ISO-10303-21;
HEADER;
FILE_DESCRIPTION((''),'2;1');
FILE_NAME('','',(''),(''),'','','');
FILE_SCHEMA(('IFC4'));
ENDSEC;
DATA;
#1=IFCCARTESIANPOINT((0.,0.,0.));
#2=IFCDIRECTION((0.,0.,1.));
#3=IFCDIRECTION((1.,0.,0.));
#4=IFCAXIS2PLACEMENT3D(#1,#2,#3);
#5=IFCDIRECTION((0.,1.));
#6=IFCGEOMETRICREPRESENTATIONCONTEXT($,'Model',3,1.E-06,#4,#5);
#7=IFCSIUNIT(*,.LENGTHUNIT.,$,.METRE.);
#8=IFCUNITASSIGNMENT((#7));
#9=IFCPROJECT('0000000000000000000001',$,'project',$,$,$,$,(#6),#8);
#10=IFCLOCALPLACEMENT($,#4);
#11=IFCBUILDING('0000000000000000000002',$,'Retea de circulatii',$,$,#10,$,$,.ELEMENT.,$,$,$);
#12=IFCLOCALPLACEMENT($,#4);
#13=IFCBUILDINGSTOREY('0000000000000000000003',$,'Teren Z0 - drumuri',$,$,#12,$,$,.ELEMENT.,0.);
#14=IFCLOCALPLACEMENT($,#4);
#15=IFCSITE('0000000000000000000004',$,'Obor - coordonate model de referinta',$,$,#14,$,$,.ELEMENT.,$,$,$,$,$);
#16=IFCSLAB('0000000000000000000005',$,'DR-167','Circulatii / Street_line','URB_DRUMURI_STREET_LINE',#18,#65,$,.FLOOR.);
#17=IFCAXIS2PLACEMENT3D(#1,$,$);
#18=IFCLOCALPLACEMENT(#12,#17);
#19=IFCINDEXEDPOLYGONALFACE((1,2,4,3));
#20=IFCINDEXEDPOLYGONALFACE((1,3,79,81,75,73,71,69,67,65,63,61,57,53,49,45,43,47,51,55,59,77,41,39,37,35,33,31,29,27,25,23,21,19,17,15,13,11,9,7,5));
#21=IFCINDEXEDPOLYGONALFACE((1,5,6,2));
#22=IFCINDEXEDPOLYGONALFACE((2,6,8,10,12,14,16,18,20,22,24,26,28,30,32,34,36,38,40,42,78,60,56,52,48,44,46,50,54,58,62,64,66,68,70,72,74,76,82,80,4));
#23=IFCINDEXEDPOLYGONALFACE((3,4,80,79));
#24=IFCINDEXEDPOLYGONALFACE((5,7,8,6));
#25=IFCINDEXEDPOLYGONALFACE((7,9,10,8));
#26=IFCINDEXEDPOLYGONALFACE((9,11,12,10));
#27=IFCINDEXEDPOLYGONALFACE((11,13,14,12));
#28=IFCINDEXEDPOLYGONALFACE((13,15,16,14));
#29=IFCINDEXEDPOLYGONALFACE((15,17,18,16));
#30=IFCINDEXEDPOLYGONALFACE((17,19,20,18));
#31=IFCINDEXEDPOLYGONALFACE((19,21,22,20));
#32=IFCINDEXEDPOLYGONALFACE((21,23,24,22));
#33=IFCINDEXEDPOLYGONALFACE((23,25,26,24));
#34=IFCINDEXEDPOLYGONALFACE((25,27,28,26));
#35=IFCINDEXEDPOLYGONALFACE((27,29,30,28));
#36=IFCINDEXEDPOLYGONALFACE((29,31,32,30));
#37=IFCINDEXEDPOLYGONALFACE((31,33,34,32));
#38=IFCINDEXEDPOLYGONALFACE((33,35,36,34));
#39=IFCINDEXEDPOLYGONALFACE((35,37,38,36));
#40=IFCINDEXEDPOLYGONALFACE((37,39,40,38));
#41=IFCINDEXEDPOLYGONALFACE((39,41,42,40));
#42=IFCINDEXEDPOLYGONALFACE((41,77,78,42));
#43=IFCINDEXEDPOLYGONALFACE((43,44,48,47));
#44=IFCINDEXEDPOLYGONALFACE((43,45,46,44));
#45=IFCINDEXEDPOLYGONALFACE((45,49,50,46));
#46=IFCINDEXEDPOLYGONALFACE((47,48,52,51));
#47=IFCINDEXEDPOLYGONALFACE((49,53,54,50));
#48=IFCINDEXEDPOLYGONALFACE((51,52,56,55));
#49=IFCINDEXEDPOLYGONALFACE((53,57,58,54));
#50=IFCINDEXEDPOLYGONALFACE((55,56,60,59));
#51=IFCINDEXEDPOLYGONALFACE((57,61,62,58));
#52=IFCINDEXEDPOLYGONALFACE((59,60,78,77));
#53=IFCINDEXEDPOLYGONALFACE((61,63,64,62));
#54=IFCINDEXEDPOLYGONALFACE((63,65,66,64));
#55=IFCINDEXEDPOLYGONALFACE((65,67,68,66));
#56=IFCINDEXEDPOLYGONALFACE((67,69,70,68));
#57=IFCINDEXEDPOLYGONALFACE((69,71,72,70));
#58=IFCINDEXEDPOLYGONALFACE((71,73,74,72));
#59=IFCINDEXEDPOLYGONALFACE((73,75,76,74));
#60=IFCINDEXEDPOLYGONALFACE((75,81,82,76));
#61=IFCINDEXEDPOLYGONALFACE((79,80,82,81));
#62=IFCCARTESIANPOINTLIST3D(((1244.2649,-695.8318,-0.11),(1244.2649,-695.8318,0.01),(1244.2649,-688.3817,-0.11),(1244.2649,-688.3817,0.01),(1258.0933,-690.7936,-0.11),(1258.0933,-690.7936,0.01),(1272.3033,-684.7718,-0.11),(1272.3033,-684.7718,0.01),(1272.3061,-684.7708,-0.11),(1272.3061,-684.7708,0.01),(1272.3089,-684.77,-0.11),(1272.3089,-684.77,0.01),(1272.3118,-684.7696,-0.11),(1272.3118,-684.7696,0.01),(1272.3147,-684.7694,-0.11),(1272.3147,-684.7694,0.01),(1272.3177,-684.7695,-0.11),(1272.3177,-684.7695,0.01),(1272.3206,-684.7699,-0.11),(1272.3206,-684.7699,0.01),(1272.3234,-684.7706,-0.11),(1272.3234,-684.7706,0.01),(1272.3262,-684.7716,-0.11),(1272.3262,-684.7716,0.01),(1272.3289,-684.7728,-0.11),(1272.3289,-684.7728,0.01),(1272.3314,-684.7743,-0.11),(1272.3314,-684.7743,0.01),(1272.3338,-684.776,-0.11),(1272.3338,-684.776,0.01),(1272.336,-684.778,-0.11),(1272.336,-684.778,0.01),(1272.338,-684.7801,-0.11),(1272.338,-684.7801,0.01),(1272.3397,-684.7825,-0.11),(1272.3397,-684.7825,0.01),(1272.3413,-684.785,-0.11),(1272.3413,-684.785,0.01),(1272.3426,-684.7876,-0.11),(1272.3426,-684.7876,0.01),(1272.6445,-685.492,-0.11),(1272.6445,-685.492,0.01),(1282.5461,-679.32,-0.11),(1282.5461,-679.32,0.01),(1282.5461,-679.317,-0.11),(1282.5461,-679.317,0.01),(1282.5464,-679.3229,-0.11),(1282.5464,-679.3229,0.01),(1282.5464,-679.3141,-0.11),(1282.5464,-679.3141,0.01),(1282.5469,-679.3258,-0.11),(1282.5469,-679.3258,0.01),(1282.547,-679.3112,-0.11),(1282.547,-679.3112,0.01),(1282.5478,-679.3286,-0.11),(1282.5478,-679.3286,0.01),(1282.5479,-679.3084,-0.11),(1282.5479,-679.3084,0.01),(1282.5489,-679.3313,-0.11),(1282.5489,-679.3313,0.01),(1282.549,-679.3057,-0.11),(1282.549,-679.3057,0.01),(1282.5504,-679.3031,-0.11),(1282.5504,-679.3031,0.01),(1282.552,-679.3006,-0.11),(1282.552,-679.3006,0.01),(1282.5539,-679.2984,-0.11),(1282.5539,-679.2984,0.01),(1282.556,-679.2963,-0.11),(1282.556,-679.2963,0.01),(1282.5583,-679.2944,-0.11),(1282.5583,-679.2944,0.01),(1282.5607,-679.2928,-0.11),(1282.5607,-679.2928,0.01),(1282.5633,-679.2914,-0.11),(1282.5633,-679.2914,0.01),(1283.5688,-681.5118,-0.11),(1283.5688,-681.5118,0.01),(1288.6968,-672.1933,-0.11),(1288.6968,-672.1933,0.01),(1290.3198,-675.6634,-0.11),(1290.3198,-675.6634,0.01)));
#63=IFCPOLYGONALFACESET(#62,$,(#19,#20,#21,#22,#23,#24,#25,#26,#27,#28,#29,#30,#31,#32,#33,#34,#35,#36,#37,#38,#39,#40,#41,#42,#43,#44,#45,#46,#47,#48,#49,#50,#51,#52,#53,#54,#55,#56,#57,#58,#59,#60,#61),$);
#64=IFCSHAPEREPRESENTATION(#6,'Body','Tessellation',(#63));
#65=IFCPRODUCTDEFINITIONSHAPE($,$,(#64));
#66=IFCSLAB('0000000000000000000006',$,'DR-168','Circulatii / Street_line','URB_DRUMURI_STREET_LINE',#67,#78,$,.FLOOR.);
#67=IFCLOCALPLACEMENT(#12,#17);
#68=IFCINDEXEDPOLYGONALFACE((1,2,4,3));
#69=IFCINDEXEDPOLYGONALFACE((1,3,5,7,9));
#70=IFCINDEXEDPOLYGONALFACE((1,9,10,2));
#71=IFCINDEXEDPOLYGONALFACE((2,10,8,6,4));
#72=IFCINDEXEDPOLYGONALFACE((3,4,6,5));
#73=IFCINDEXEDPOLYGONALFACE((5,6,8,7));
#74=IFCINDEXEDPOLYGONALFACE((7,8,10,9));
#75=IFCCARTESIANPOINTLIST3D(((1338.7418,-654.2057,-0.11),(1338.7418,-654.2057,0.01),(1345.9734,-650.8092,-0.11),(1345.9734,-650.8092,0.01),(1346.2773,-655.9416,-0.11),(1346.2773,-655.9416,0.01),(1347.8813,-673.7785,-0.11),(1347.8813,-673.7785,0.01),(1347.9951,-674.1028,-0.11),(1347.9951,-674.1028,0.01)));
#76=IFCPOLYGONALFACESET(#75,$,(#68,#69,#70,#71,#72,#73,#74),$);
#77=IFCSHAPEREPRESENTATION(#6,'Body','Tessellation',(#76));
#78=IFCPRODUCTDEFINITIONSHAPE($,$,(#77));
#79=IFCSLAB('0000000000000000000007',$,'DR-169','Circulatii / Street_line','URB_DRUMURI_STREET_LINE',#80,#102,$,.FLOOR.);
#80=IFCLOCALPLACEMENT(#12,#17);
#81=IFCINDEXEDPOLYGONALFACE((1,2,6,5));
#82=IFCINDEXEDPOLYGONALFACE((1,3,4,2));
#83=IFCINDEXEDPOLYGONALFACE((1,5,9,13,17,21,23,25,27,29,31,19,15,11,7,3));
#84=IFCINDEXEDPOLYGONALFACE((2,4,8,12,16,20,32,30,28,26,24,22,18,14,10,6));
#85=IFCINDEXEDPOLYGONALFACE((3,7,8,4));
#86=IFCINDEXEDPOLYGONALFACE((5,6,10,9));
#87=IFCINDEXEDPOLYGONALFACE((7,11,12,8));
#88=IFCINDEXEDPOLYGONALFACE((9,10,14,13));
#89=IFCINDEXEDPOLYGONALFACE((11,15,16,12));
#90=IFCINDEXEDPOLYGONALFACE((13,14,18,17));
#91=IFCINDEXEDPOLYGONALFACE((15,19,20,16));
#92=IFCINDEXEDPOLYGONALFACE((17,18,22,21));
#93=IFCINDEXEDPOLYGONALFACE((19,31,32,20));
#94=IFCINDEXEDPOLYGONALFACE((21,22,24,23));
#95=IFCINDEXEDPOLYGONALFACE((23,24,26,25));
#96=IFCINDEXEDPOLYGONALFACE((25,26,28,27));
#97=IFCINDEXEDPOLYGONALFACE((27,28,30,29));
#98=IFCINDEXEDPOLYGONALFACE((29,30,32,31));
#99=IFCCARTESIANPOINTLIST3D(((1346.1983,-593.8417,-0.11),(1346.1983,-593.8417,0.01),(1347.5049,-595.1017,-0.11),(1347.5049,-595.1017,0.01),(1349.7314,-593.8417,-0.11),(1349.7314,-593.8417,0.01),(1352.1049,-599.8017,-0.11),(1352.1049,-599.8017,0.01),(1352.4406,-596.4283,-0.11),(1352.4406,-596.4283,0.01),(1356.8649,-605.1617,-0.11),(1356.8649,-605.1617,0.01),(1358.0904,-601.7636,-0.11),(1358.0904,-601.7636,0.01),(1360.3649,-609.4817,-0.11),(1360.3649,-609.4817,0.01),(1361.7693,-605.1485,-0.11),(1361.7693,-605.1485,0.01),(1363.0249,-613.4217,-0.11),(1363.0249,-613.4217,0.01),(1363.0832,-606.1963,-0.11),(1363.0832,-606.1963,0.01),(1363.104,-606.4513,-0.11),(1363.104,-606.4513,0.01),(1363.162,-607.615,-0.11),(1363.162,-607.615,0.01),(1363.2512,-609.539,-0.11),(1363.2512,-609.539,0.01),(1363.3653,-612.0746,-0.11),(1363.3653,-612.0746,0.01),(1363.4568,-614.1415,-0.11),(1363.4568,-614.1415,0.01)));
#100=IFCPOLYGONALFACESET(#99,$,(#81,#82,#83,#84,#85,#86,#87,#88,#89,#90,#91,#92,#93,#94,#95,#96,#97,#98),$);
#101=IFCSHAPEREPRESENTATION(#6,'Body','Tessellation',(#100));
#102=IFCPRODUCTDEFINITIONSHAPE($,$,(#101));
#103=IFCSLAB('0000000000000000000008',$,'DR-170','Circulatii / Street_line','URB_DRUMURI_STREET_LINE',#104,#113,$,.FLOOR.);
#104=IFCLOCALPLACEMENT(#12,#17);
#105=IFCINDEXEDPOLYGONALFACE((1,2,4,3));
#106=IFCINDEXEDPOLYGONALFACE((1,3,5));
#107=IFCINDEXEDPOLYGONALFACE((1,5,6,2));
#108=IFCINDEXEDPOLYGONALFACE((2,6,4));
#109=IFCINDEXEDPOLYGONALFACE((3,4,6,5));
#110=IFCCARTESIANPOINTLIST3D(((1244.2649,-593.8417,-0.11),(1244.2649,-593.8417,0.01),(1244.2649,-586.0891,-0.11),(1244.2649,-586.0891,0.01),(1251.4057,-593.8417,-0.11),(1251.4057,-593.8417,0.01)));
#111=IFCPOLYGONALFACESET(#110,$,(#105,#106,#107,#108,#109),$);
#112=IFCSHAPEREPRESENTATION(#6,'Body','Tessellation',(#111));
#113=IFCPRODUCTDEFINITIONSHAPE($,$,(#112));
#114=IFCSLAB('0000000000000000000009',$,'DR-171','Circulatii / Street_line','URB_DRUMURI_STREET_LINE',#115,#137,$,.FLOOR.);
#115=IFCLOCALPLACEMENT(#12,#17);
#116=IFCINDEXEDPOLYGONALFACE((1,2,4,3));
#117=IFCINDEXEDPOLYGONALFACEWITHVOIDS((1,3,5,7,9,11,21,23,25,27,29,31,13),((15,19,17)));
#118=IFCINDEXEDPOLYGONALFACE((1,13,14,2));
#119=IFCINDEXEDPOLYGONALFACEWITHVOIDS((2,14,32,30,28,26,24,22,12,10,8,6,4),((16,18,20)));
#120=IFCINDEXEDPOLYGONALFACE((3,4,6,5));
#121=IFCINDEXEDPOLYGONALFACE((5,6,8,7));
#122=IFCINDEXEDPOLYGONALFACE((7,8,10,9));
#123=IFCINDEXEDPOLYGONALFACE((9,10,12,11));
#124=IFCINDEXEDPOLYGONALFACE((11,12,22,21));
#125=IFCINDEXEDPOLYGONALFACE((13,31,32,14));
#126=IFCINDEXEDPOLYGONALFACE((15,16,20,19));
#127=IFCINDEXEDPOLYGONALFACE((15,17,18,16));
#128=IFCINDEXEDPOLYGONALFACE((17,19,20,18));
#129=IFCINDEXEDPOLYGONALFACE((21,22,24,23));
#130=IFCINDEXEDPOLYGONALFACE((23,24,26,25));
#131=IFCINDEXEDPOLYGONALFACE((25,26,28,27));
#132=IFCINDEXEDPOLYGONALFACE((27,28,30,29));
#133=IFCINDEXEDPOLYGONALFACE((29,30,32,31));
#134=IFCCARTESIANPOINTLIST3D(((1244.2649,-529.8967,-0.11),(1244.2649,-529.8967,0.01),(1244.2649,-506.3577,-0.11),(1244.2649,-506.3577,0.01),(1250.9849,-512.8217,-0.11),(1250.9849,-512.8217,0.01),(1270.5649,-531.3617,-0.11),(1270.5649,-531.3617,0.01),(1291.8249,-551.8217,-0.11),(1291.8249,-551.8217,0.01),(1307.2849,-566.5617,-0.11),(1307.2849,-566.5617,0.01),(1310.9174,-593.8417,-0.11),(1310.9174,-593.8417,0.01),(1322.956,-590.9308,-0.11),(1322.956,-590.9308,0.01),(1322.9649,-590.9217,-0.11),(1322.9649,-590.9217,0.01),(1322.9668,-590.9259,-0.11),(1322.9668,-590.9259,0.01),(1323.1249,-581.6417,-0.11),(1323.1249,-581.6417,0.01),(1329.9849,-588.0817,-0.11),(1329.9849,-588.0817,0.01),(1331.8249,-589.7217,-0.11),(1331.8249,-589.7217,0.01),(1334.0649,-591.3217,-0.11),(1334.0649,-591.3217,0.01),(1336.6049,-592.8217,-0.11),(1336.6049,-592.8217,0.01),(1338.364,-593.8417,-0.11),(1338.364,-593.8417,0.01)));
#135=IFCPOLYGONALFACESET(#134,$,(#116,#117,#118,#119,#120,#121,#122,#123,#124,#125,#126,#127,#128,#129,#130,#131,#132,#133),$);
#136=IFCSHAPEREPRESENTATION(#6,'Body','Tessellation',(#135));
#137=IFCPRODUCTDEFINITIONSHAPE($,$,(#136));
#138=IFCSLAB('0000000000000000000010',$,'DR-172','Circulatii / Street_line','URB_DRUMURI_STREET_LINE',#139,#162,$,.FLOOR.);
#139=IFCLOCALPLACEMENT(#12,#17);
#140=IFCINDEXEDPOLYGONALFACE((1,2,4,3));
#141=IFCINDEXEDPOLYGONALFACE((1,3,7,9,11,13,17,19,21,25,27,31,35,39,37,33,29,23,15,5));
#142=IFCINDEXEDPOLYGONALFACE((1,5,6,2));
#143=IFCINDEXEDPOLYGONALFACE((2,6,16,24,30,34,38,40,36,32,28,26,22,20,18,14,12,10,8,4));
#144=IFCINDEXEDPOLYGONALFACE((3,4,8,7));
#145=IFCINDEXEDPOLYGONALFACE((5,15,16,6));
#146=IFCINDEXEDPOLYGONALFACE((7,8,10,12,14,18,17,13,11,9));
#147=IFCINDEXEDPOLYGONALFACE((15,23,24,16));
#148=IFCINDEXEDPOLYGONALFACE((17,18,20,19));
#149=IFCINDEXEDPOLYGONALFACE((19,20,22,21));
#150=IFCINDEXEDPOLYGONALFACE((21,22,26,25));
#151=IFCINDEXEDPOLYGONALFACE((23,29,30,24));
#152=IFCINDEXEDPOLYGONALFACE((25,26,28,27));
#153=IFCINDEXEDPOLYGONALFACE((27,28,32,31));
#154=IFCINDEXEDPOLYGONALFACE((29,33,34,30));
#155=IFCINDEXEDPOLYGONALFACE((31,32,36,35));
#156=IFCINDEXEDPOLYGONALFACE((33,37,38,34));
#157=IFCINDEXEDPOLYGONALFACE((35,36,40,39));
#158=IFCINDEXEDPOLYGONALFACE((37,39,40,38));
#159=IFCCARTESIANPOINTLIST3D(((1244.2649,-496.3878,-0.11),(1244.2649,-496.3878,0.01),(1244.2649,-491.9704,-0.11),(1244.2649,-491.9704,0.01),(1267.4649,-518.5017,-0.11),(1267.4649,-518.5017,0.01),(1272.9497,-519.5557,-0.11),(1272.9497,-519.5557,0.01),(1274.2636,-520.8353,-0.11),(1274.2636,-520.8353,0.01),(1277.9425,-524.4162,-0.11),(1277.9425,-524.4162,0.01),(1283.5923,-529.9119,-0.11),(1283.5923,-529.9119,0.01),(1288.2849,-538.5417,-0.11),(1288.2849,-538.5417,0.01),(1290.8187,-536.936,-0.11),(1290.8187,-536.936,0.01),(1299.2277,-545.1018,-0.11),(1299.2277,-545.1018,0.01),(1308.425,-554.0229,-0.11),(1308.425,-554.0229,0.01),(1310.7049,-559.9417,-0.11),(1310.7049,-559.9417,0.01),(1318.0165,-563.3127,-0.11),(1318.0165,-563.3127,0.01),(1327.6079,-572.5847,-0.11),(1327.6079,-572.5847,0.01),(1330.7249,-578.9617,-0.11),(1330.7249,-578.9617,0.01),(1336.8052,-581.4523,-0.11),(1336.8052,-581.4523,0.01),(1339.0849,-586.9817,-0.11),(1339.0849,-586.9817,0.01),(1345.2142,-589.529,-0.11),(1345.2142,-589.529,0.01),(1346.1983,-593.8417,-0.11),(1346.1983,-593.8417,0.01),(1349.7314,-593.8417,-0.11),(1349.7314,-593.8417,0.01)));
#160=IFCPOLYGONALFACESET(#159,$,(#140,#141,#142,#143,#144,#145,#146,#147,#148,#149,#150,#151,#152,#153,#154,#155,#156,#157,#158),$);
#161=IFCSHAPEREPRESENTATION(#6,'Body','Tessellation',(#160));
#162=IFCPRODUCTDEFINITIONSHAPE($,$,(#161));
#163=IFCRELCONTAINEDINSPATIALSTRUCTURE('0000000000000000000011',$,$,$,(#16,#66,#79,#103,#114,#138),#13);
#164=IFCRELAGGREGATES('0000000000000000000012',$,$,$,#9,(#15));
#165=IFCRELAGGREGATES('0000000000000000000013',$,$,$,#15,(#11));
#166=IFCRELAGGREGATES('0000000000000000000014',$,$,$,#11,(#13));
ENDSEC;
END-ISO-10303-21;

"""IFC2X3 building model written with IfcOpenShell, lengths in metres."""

from ifc_helpers import new_model, si_unit, direction, frame, origin_with_axes, place, context, project, spatial, polyline, outline, extrude, element, save


model = new_model("IFC2X3")

# Units and contexts
model_context = context("Model", 3, precision=1e-06, world=origin_with_axes(), true_north=direction((0.0, 1.0)))
ifc_project = project(units=[si_unit("LENGTHUNIT", "METRE")], contexts=[model_context])

# Site, building, storey
site_placement = place(None, origin_with_axes())
site = spatial("IfcSite", under=ifc_project, at=site_placement, Name="Obor - coordonate model de referinta", CompositionType="ELEMENT")
building_placement = place(None, origin_with_axes())
building = spatial("IfcBuilding", under=site, at=building_placement, Name="Retea de circulatii", CompositionType="ELEMENT")
storey_placement = place(None, origin_with_axes())
storey = spatial("IfcBuildingStorey", under=building, at=storey_placement, Name="Teren Z0 - drumuri", CompositionType="ELEMENT", Elevation=0.0)

# Slabs
slab_1_placement = place(None, origin_with_axes())
element("IfcSlab", 1, at=slab_1_placement, inside=storey, Name="DR-167", Description="Circulatii / Street_line", ObjectType="URB_DRUMURI_STREET_LINE", PredefinedType="FLOOR", context=model_context, shape_type="SweptSolid", body=[
    extrude(outline(polyline([(1272.3413, -684.785), (1272.3426, -684.7876), (1272.6445, -685.492), (1283.5688, -681.5118), (1282.5489, -679.3313), (1282.5478, -679.3286), (1282.5469, -679.3258), (1282.5464, -679.3229), (1282.5461, -679.32), (1282.5461, -679.317), (1282.5464, -679.3141), (1282.547, -679.3112), (1282.5479, -679.3084), (1282.549, -679.3057), (1282.5504, -679.3031), (1282.552, -679.3006), (1282.5539, -679.2984), (1282.556, -679.2963), (1282.5583, -679.2944), (1282.5607, -679.2928), (1282.5633, -679.2914), (1290.3198, -675.6634), (1288.6968, -672.1933), (1244.2649, -688.3817), (1244.2649, -695.8318), (1258.0933, -690.7936), (1272.3033, -684.7718), (1272.3061, -684.7708), (1272.3089, -684.77), (1272.3118, -684.7696), (1272.3147, -684.7694), (1272.3177, -684.7695), (1272.3206, -684.7699), (1272.3234, -684.7706), (1272.3262, -684.7716), (1272.3289, -684.7728), (1272.3314, -684.7743), (1272.3338, -684.776), (1272.336, -684.778), (1272.338, -684.7801), (1272.3397, -684.7825), (1272.3413, -684.785)])), frame((0.0, 0.0, -0.11), z_axis=(0.0, 0.0, 1.0), x_axis=(1.0, 0.0, 0.0)), (0.0, 0.0, 1.0), 0.12),
])
slab_2_placement = place(None, origin_with_axes())
element("IfcSlab", 2, at=slab_2_placement, inside=storey, Name="DR-168", Description="Circulatii / Street_line", ObjectType="URB_DRUMURI_STREET_LINE", PredefinedType="FLOOR", context=model_context, shape_type="SweptSolid", body=[
    extrude(outline(polyline([(1347.8813, -673.7785), (1346.2773, -655.9416), (1345.9734, -650.8092), (1338.7418, -654.2057), (1347.9951, -674.1028), (1347.8813, -673.7785)])), frame((0.0, 0.0, -0.11), z_axis=(0.0, 0.0, 1.0), x_axis=(1.0, 0.0, 0.0)), (0.0, 0.0, 1.0), 0.12),
])
slab_3_placement = place(None, origin_with_axes())
element("IfcSlab", 3, at=slab_3_placement, inside=storey, Name="DR-169", Description="Circulatii / Street_line", ObjectType="URB_DRUMURI_STREET_LINE", PredefinedType="FLOOR", context=model_context, shape_type="SweptSolid", body=[
    extrude(outline(polyline([(1363.0832, -606.1963), (1361.7693, -605.1485), (1358.0904, -601.7636), (1352.4406, -596.4283), (1349.7314, -593.8417), (1346.1983, -593.8417), (1347.5049, -595.1017), (1352.1049, -599.8017), (1356.8649, -605.1617), (1360.3649, -609.4817), (1363.0249, -613.4217), (1363.4568, -614.1415), (1363.3653, -612.0746), (1363.2512, -609.539), (1363.162, -607.615), (1363.104, -606.4513), (1363.0832, -606.1963)])), frame((0.0, 0.0, -0.11), z_axis=(0.0, 0.0, 1.0), x_axis=(1.0, 0.0, 0.0)), (0.0, 0.0, 1.0), 0.12),
])
slab_4_placement = place(None, origin_with_axes())
element("IfcSlab", 4, at=slab_4_placement, inside=storey, Name="DR-170", Description="Circulatii / Street_line", ObjectType="URB_DRUMURI_STREET_LINE", PredefinedType="FLOOR", context=model_context, shape_type="SweptSolid", body=[
    extrude(outline(polyline([(1244.2649, -593.8417), (1251.4057, -593.8417), (1244.2649, -586.0891), (1244.2649, -593.8417)])), frame((0.0, 0.0, -0.11), z_axis=(0.0, 0.0, 1.0), x_axis=(1.0, 0.0, 0.0)), (0.0, 0.0, 1.0), 0.12),
])
slab_5_placement = place(None, origin_with_axes())
element("IfcSlab", 5, at=slab_5_placement, inside=storey, Name="DR-171", Description="Circulatii / Street_line", ObjectType="URB_DRUMURI_STREET_LINE", PredefinedType="FLOOR", context=model_context, shape_type="SweptSolid", body=[
    extrude(outline(polyline([(1291.8249, -551.8217), (1270.5649, -531.3617), (1250.9849, -512.8217), (1244.2649, -506.3577), (1244.2649, -529.8967), (1310.9174, -593.8417), (1338.364, -593.8417), (1336.6049, -592.8217), (1334.0649, -591.3217), (1331.8249, -589.7217), (1329.9849, -588.0817), (1323.1249, -581.6417), (1323.1249, -581.6417), (1307.2849, -566.5617), (1291.8249, -551.8217)]), holes=[polyline([(1322.9668, -590.9259), (1322.956, -590.9308), (1322.9649, -590.9217), (1322.9668, -590.9259)])]), frame((0.0, 0.0, -0.11), z_axis=(0.0, 0.0, 1.0), x_axis=(1.0, 0.0, 0.0)), (0.0, 0.0, 1.0), 0.12),
])
slab_6_placement = place(None, origin_with_axes())
element("IfcSlab", 6, at=slab_6_placement, inside=storey, Name="DR-172", Description="Circulatii / Street_line", ObjectType="URB_DRUMURI_STREET_LINE", PredefinedType="FLOOR", context=model_context, shape_type="SweptSolid", body=[
    extrude(outline(polyline([(1277.9425, -524.4162), (1274.2636, -520.8353), (1272.9497, -519.5557), (1244.2649, -491.9704), (1244.2649, -496.3878), (1267.4649, -518.5017), (1288.2849, -538.5417), (1310.7049, -559.9417), (1330.7249, -578.9617), (1339.0849, -586.9817), (1346.1983, -593.8417), (1349.7314, -593.8417), (1345.2142, -589.529), (1336.8052, -581.4523), (1327.6079, -572.5847), (1318.0165, -563.3127), (1308.425, -554.0229), (1299.2277, -545.1018), (1290.8187, -536.936), (1283.5923, -529.9119), (1277.9425, -524.4162)])), frame((0.0, 0.0, -0.11), z_axis=(0.0, 0.0, 1.0), x_axis=(1.0, 0.0, 0.0)), (0.0, 0.0, 1.0), 0.12),
])

save(model, "model.ifc")
